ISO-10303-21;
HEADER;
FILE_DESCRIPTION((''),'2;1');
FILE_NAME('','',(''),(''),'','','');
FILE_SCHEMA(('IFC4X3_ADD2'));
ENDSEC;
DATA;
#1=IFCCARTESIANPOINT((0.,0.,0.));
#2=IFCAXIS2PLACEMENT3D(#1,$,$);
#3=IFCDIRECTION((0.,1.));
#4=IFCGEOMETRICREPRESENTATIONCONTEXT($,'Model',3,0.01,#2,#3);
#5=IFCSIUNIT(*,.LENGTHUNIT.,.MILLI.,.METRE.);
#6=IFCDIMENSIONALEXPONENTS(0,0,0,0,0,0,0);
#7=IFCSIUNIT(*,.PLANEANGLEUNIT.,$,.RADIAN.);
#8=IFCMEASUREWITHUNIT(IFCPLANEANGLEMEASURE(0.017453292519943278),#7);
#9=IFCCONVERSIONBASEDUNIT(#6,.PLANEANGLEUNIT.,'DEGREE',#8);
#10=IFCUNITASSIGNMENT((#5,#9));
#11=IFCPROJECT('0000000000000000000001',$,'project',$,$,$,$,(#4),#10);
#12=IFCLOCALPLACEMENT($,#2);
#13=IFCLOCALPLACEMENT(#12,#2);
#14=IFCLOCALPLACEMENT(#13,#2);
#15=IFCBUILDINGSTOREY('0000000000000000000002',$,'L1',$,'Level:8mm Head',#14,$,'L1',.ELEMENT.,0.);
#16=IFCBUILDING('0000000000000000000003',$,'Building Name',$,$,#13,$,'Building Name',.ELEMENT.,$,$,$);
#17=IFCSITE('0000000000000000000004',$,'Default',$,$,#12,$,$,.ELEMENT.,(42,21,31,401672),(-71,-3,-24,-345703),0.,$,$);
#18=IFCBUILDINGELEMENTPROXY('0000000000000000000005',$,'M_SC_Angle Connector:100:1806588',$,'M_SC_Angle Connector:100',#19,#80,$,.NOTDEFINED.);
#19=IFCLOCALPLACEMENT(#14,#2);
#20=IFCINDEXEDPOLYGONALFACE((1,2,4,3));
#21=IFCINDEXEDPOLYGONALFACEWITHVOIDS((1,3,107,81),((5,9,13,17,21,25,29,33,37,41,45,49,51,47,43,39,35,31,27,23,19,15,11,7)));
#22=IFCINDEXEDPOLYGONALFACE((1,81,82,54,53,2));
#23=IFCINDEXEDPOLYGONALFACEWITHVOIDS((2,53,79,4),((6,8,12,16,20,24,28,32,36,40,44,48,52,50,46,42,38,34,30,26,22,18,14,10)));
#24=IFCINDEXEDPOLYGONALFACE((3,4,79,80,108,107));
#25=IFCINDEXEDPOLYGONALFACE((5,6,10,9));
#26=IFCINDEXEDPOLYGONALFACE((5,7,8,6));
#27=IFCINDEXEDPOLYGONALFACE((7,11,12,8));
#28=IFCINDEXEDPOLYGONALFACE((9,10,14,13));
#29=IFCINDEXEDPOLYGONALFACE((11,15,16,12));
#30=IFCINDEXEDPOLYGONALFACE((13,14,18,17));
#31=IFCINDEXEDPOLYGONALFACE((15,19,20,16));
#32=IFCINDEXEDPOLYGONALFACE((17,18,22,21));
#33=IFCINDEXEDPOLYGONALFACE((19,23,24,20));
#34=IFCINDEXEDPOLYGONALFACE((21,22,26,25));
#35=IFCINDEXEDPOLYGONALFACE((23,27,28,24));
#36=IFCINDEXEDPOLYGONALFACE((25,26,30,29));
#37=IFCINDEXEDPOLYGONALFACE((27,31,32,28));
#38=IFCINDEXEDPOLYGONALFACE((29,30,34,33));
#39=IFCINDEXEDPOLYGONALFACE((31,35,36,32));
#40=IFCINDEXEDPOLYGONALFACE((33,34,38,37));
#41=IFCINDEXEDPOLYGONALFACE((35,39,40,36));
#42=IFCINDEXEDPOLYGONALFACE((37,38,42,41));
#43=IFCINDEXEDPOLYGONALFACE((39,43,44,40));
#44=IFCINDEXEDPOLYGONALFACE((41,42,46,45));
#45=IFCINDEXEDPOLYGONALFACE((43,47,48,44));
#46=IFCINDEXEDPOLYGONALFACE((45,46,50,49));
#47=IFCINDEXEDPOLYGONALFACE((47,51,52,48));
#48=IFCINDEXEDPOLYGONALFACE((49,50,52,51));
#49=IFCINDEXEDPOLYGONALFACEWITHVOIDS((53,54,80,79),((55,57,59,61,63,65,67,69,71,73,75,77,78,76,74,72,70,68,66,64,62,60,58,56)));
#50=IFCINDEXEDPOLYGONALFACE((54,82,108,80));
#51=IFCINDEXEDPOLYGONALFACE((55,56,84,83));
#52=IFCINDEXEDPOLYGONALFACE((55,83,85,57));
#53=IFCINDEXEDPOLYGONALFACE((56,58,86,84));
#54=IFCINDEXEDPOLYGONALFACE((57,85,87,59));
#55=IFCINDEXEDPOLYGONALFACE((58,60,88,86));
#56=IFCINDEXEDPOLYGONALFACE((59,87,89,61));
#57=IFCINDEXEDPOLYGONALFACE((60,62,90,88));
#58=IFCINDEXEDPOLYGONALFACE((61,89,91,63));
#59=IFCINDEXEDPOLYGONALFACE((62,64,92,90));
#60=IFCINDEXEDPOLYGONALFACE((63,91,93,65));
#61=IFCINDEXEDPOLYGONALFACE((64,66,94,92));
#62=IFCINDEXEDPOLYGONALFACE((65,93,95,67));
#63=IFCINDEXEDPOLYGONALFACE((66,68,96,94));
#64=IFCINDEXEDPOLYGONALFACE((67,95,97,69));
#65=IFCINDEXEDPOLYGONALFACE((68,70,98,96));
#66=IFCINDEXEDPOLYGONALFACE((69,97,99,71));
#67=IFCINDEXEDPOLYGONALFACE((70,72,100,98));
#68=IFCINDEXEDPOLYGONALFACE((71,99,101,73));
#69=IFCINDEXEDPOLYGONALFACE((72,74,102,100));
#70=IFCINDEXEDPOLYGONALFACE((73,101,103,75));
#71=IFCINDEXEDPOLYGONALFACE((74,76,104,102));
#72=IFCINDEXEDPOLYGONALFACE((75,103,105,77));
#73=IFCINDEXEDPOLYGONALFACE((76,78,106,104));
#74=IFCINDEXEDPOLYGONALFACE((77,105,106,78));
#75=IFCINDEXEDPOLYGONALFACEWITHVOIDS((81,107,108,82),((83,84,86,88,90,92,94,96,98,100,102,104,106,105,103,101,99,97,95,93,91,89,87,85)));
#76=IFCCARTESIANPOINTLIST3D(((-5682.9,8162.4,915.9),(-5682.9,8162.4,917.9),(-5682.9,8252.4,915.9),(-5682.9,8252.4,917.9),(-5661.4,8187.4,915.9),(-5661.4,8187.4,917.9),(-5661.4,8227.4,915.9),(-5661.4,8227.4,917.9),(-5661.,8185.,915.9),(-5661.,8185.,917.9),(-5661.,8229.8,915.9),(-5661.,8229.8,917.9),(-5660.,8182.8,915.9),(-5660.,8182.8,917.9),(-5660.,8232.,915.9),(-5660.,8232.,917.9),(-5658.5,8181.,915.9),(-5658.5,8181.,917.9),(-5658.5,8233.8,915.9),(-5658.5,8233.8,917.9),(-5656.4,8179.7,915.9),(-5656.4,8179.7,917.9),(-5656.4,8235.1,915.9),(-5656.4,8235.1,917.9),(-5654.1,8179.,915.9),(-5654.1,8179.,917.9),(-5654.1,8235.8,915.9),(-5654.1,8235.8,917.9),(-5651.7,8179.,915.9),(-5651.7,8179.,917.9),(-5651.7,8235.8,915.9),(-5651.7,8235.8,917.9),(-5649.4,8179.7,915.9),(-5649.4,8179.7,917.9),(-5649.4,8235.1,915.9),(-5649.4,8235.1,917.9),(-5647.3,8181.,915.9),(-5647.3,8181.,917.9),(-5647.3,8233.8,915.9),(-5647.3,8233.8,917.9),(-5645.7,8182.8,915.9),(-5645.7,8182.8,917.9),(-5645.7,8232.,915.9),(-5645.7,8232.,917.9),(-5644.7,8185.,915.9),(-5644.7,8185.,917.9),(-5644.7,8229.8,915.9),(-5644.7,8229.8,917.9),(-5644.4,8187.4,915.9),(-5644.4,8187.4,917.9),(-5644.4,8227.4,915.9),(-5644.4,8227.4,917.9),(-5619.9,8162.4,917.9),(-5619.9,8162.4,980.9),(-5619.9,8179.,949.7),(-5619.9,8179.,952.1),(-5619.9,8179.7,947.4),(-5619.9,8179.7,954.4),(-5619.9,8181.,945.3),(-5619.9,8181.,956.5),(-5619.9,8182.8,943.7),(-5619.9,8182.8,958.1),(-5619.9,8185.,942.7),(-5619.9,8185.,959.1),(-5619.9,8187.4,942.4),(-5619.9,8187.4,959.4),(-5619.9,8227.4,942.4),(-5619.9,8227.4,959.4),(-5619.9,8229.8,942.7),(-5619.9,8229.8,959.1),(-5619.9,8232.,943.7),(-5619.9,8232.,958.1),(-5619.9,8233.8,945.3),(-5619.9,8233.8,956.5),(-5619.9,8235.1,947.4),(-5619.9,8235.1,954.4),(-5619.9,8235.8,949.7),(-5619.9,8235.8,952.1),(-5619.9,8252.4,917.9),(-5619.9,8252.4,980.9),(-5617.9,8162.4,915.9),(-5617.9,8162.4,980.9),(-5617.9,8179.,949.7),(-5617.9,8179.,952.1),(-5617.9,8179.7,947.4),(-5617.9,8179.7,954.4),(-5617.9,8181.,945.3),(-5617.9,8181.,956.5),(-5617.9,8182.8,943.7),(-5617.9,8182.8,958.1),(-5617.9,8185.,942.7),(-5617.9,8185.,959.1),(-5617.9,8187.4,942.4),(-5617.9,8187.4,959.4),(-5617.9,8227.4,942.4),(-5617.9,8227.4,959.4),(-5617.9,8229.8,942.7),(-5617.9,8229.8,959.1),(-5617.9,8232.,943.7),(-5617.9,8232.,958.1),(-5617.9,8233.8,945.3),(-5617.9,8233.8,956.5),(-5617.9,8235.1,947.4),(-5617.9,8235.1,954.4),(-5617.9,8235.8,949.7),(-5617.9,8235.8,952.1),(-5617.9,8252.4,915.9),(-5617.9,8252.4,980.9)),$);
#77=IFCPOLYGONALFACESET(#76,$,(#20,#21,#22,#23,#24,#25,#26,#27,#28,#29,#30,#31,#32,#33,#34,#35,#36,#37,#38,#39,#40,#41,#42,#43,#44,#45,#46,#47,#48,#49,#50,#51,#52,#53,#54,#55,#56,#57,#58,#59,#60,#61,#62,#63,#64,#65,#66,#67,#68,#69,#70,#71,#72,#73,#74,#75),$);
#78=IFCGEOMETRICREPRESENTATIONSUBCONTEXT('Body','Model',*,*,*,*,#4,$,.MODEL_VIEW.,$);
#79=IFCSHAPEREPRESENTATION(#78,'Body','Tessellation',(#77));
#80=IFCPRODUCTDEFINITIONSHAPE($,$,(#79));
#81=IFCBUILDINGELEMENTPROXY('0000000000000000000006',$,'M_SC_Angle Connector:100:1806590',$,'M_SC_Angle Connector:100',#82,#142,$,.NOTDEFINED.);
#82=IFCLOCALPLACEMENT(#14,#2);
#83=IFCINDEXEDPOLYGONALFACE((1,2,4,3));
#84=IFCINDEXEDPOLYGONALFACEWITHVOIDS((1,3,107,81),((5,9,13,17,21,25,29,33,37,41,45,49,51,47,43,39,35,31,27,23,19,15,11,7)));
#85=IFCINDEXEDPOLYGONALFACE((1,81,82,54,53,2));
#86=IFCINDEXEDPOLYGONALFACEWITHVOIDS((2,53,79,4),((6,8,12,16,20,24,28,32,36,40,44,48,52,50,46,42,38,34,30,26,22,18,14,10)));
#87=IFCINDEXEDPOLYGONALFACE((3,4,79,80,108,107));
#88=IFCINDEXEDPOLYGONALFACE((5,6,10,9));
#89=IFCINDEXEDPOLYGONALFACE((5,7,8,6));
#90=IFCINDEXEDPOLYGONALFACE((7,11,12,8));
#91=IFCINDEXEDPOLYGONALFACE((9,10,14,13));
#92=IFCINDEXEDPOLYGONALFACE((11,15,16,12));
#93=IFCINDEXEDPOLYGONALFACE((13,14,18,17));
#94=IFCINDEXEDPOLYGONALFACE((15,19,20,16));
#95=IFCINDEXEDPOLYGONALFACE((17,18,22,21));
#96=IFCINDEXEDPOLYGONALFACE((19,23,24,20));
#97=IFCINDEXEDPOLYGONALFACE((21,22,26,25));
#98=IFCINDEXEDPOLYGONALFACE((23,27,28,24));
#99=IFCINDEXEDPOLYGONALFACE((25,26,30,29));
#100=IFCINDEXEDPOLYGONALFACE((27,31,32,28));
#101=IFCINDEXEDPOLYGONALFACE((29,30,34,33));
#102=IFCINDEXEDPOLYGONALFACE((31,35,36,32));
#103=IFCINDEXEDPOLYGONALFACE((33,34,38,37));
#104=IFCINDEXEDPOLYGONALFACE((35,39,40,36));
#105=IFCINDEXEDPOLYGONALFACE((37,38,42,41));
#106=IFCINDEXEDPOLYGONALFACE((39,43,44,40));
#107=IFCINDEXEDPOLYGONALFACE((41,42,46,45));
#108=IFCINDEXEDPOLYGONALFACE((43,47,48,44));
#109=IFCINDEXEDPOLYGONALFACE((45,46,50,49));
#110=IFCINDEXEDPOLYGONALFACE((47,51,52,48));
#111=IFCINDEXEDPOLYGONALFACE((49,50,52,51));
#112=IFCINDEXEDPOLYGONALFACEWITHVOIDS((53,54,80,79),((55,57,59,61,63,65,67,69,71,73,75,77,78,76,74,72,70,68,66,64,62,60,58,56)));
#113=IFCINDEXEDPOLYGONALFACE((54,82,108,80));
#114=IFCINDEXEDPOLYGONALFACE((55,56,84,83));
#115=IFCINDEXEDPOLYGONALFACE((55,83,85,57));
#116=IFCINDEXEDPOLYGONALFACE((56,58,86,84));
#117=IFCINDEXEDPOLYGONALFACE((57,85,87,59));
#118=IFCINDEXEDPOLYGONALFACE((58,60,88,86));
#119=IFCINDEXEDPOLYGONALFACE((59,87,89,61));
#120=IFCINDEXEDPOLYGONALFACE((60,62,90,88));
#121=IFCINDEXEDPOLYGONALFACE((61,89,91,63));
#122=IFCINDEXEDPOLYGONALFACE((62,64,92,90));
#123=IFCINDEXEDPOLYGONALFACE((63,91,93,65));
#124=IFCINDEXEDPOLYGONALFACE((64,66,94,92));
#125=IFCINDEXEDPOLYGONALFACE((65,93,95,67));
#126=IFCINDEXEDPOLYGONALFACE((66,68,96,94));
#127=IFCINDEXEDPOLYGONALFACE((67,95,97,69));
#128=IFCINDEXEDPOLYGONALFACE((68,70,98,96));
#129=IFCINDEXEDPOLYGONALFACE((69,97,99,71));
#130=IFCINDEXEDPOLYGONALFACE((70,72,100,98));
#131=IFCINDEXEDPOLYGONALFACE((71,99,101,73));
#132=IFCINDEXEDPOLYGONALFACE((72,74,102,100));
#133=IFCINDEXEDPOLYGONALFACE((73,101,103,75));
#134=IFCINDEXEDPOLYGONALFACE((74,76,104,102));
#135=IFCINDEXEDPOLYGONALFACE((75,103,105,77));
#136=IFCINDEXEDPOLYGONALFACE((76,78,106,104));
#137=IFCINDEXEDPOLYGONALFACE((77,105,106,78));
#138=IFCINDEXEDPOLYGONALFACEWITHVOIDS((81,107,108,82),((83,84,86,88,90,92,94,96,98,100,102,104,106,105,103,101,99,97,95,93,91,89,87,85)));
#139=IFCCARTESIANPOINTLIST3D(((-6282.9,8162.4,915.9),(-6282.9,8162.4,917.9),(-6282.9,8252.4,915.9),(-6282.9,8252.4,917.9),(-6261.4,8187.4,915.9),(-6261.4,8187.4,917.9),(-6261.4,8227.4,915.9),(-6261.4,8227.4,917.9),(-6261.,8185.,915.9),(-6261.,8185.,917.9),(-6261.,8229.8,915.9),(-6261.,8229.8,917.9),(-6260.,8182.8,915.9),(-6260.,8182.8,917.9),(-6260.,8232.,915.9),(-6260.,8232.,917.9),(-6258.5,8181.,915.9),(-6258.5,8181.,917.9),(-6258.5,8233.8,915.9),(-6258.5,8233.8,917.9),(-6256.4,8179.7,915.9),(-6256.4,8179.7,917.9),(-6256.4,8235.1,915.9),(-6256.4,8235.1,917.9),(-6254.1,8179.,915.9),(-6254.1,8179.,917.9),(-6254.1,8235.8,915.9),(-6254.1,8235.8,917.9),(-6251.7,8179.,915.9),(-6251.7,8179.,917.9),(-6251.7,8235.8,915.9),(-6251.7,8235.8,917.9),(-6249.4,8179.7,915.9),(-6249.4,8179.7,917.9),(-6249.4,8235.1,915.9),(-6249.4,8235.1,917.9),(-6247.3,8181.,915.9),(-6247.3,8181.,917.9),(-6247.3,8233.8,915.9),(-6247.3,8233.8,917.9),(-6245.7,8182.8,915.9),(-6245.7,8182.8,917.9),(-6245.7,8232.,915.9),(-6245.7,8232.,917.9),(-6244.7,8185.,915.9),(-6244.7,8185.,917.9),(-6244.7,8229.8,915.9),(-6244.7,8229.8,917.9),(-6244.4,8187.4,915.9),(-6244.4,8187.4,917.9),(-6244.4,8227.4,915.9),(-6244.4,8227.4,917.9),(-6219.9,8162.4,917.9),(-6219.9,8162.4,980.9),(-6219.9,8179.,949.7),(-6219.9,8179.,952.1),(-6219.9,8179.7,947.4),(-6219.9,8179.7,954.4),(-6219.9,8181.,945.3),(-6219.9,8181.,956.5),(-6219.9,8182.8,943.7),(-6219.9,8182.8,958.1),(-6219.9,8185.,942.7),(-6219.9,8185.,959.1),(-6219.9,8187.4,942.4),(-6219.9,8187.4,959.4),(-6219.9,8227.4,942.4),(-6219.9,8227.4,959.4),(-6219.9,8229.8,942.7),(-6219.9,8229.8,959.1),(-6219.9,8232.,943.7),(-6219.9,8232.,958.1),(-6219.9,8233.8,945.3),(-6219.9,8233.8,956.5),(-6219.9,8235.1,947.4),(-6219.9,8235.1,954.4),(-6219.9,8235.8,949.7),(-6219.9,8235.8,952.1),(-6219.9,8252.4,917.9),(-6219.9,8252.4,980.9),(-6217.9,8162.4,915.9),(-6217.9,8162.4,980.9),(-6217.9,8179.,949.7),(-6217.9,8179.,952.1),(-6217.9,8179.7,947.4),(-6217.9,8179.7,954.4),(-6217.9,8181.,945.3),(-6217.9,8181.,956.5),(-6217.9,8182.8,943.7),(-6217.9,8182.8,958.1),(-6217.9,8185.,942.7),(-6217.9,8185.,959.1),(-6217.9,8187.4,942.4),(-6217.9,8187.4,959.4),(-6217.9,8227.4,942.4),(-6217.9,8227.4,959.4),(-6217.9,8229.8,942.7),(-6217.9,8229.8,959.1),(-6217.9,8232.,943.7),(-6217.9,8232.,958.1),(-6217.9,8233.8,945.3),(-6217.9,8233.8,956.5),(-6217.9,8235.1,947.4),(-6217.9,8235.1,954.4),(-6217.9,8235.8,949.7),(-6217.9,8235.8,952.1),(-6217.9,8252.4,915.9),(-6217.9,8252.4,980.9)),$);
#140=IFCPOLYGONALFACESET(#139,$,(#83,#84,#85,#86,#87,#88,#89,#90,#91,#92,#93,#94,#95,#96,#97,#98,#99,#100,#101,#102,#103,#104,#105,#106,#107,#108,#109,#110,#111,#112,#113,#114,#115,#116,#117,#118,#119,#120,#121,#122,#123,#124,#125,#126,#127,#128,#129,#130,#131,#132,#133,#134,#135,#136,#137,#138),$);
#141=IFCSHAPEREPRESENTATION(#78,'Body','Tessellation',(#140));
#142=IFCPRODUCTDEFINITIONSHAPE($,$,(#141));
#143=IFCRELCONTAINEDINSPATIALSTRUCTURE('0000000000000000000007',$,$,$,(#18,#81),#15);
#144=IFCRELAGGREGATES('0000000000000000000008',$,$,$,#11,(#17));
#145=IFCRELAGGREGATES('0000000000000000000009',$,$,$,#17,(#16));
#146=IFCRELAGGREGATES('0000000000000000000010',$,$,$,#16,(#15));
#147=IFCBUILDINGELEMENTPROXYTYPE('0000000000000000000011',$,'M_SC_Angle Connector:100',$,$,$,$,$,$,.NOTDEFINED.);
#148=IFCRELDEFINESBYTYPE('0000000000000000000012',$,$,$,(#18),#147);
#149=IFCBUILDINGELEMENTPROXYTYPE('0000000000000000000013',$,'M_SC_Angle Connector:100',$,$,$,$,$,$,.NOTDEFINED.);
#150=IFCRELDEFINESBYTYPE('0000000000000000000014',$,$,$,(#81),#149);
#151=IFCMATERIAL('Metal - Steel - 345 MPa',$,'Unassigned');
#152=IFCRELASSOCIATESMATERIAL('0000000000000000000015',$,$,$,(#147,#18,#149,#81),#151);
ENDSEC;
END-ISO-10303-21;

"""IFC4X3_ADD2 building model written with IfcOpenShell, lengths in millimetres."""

from ifc_helpers import new_model, entity, si_unit, converted_unit, direction, frame, frame_2d, origin, place, context, subcontext, project, spatial, polyline, circle_curve, parameter, trimmed, segment, composite_curve, outline, extrude, source, transform, mapped, material, type_object, type_shapes, element, save


model = new_model("IFC4X3_ADD2")

# Units and contexts
model_context = context("Model", 3, precision=0.01, world=origin(), true_north=direction((0.0, 1.0)))
body_context = subcontext(model_context, "Body", "Model", "MODEL_VIEW")
ifc_project = project(units=[si_unit("LENGTHUNIT", "METRE", prefix="MILLI"), converted_unit("PLANEANGLEUNIT", "DEGREE", entity("IfcPlaneAngleMeasure", 0.017453292519943278), si_unit("PLANEANGLEUNIT", "RADIAN"), dimensions=[0, 0, 0, 0, 0, 0, 0])], contexts=[model_context])

# Site, building, storey
site_placement = place(None, origin())
site = spatial("IfcSite", under=ifc_project, at=site_placement, Name="Default", CompositionType="ELEMENT", RefLatitude=(42, 21, 31, 401672), RefLongitude=(-71, -3, -24, -345703), RefElevation=0.0)
building_placement = place(site_placement, origin())
building = spatial("IfcBuilding", under=site, at=building_placement, Name="Building Name", LongName="Building Name", CompositionType="ELEMENT")
storey_placement = place(building_placement, origin())
storey = spatial("IfcBuildingStorey", under=building, at=storey_placement, Name="L1", ObjectType="Level:8mm Head", LongName="L1", CompositionType="ELEMENT", Elevation=0.0)

# Building element proxies, openings
ifc_material_1 = material(Name="Metal - Steel - 345 MPa", Category="Unassigned")
building_element_proxy_type_1 = type_object("IfcBuildingElementProxyType", Name="M_SC_Angle Connector:100", PredefinedType="NOTDEFINED", material=ifc_material_1)
shared_shape_1 = source(origin(), body_context, "Body", "SweptSolid", [
    extrude(outline(polyline([(-42.7, -22.3), (22.3, -22.3), (22.3, 42.7), (20.3, 42.7), (20.3, -20.3), (-42.7, -20.3), (-42.7, -22.3)])), frame((22.3, -45.0, 22.3), z_axis=(0.0, 1.0, 0.0), x_axis=(-1.0, 0.0, 0.0)), (0.0, 0.0, 1.0), 90.0),
])
type_shapes(building_element_proxy_type_1, [shared_shape_1])
proxy_1_placement = place(storey_placement, frame((-5617.9, 8207.4, 915.9), z_axis=(0.0, 0.0, 1.0), x_axis=(-1.0, 0.0, 0.0)))
proxy_1 = element("IfcBuildingElementProxy", 1, at=proxy_1_placement, inside=storey, type_object=building_element_proxy_type_1, material=ifc_material_1, Name="M_SC_Angle Connector:100:1806588", ObjectType="M_SC_Angle Connector:100", PredefinedType="NOTDEFINED", context=body_context, shape_type="MappedRepresentation", body=[
    mapped(shared_shape_1, transform((0.0, 0.0, 0.0), scale=1.0)),
])
opening_1_placement = place(storey_placement, frame((-5617.9, 8207.4, 915.9)))
element("IfcOpeningElement", 2, at=opening_1_placement, cuts=proxy_1, PredefinedType="OPENING", context=body_context, shape_type="SweptSolid", body=[
    extrude(outline(composite_curve([segment(polyline([(-20.0, -8.5), (20.0, -8.5)]), True, "CONTINUOUS"), segment(trimmed(circle_curve(frame_2d((20.0, 0.0), x_axis=(0.0, 1.0)), 8.5), [parameter(180.0)], [parameter(360.0)], True, "PARAMETER"), True, "CONTINUOUS"), segment(polyline([(20.0, 8.5), (-20.0, 8.5)]), True, "CONTINUOUS"), segment(trimmed(circle_curve(frame_2d((-20.0, 0.0), x_axis=(0.0, 1.0)), 8.5), [parameter(360.0)], [parameter(180.0)], True, "PARAMETER"), True, "CONTINUOUS")], self_intersect=False)), frame((-2.0, 0.0, 35.0), z_axis=(1.0, 0.0, 0.0), x_axis=(0.0, 1.0, 0.0)), (0.0, 0.0, 1.0), 2.0),
])
opening_2_placement = place(storey_placement, frame((-5617.9, 8207.4, 915.9)))
element("IfcOpeningElement", 3, at=opening_2_placement, cuts=proxy_1, PredefinedType="OPENING", context=body_context, shape_type="SweptSolid", body=[
    extrude(outline(composite_curve([segment(polyline([(-20.0, -8.5), (20.0, -8.5)]), True, "CONTINUOUS"), segment(trimmed(circle_curve(frame_2d((20.0, 0.0), x_axis=(0.0, -1.0)), 8.5), [parameter(360.0)], [parameter(180.0)], True, "PARAMETER"), True, "CONTINUOUS"), segment(polyline([(20.0, 8.5), (-20.0, 8.5)]), True, "CONTINUOUS"), segment(trimmed(circle_curve(frame_2d((-20.0, 0.0), x_axis=(0.0, -1.0)), 8.5), [parameter(180.0)], [parameter(360.0)], True, "PARAMETER"), True, "CONTINUOUS")], self_intersect=False)), frame((-35.0, 0.0, 2.0), z_axis=(0.0, 0.0, -1.0), x_axis=(0.0, 1.0, 0.0)), (0.0, 0.0, 1.0), 2.0),
])
building_element_proxy_type_2 = type_object("IfcBuildingElementProxyType", Name="M_SC_Angle Connector:100", PredefinedType="NOTDEFINED", material=ifc_material_1)
shared_shape_2 = source(origin(), body_context, "Body", "SweptSolid", [
    extrude(outline(polyline([(-42.7, -22.3), (22.3, -22.3), (22.3, 42.7), (20.3, 42.7), (20.3, -20.3), (-42.7, -20.3), (-42.7, -22.3)])), frame((22.3, -45.0, 22.3), z_axis=(0.0, 1.0, 0.0), x_axis=(-1.0, 0.0, 0.0)), (0.0, 0.0, 1.0), 90.0),
])
type_shapes(building_element_proxy_type_2, [shared_shape_2])
proxy_2_placement = place(storey_placement, frame((-6217.9, 8207.4, 915.9), z_axis=(0.0, 0.0, 1.0), x_axis=(-1.0, 0.0, 0.0)))
proxy_2 = element("IfcBuildingElementProxy", 4, at=proxy_2_placement, inside=storey, type_object=building_element_proxy_type_2, material=ifc_material_1, Name="M_SC_Angle Connector:100:1806590", ObjectType="M_SC_Angle Connector:100", PredefinedType="NOTDEFINED", context=body_context, shape_type="MappedRepresentation", body=[
    mapped(shared_shape_2, transform((0.0, 0.0, 0.0), scale=1.0)),
])
opening_3_placement = place(storey_placement, frame((-6217.9, 8207.4, 915.9)))
element("IfcOpeningElement", 5, at=opening_3_placement, cuts=proxy_2, PredefinedType="OPENING", context=body_context, shape_type="SweptSolid", body=[
    extrude(outline(composite_curve([segment(polyline([(-20.0, -8.5), (20.0, -8.5)]), True, "CONTINUOUS"), segment(trimmed(circle_curve(frame_2d((20.0, 0.0), x_axis=(0.0, 1.0)), 8.5), [parameter(180.0)], [parameter(360.0)], True, "PARAMETER"), True, "CONTINUOUS"), segment(polyline([(20.0, 8.5), (-20.0, 8.5)]), True, "CONTINUOUS"), segment(trimmed(circle_curve(frame_2d((-20.0, 0.0), x_axis=(0.0, 1.0)), 8.5), [parameter(360.0)], [parameter(180.0)], True, "PARAMETER"), True, "CONTINUOUS")], self_intersect=False)), frame((-2.0, 0.0, 35.0), z_axis=(1.0, 0.0, 0.0), x_axis=(0.0, 1.0, 0.0)), (0.0, 0.0, 1.0), 2.0),
])
opening_4_placement = place(storey_placement, frame((-6217.9, 8207.4, 915.9)))
element("IfcOpeningElement", 6, at=opening_4_placement, cuts=proxy_2, PredefinedType="OPENING", context=body_context, shape_type="SweptSolid", body=[
    extrude(outline(composite_curve([segment(polyline([(-20.0, -8.5), (20.0, -8.5)]), True, "CONTINUOUS"), segment(trimmed(circle_curve(frame_2d((20.0, 0.0), x_axis=(0.0, -1.0)), 8.5), [parameter(360.0)], [parameter(180.0)], True, "PARAMETER"), True, "CONTINUOUS"), segment(polyline([(20.0, 8.5), (-20.0, 8.5)]), True, "CONTINUOUS"), segment(trimmed(circle_curve(frame_2d((-20.0, 0.0), x_axis=(0.0, -1.0)), 8.5), [parameter(180.0)], [parameter(360.0)], True, "PARAMETER"), True, "CONTINUOUS")], self_intersect=False)), frame((-35.0, 0.0, 2.0), z_axis=(0.0, 0.0, -1.0), x_axis=(0.0, 1.0, 0.0)), (0.0, 0.0, 1.0), 2.0),
])

save(model, "model.ifc")
